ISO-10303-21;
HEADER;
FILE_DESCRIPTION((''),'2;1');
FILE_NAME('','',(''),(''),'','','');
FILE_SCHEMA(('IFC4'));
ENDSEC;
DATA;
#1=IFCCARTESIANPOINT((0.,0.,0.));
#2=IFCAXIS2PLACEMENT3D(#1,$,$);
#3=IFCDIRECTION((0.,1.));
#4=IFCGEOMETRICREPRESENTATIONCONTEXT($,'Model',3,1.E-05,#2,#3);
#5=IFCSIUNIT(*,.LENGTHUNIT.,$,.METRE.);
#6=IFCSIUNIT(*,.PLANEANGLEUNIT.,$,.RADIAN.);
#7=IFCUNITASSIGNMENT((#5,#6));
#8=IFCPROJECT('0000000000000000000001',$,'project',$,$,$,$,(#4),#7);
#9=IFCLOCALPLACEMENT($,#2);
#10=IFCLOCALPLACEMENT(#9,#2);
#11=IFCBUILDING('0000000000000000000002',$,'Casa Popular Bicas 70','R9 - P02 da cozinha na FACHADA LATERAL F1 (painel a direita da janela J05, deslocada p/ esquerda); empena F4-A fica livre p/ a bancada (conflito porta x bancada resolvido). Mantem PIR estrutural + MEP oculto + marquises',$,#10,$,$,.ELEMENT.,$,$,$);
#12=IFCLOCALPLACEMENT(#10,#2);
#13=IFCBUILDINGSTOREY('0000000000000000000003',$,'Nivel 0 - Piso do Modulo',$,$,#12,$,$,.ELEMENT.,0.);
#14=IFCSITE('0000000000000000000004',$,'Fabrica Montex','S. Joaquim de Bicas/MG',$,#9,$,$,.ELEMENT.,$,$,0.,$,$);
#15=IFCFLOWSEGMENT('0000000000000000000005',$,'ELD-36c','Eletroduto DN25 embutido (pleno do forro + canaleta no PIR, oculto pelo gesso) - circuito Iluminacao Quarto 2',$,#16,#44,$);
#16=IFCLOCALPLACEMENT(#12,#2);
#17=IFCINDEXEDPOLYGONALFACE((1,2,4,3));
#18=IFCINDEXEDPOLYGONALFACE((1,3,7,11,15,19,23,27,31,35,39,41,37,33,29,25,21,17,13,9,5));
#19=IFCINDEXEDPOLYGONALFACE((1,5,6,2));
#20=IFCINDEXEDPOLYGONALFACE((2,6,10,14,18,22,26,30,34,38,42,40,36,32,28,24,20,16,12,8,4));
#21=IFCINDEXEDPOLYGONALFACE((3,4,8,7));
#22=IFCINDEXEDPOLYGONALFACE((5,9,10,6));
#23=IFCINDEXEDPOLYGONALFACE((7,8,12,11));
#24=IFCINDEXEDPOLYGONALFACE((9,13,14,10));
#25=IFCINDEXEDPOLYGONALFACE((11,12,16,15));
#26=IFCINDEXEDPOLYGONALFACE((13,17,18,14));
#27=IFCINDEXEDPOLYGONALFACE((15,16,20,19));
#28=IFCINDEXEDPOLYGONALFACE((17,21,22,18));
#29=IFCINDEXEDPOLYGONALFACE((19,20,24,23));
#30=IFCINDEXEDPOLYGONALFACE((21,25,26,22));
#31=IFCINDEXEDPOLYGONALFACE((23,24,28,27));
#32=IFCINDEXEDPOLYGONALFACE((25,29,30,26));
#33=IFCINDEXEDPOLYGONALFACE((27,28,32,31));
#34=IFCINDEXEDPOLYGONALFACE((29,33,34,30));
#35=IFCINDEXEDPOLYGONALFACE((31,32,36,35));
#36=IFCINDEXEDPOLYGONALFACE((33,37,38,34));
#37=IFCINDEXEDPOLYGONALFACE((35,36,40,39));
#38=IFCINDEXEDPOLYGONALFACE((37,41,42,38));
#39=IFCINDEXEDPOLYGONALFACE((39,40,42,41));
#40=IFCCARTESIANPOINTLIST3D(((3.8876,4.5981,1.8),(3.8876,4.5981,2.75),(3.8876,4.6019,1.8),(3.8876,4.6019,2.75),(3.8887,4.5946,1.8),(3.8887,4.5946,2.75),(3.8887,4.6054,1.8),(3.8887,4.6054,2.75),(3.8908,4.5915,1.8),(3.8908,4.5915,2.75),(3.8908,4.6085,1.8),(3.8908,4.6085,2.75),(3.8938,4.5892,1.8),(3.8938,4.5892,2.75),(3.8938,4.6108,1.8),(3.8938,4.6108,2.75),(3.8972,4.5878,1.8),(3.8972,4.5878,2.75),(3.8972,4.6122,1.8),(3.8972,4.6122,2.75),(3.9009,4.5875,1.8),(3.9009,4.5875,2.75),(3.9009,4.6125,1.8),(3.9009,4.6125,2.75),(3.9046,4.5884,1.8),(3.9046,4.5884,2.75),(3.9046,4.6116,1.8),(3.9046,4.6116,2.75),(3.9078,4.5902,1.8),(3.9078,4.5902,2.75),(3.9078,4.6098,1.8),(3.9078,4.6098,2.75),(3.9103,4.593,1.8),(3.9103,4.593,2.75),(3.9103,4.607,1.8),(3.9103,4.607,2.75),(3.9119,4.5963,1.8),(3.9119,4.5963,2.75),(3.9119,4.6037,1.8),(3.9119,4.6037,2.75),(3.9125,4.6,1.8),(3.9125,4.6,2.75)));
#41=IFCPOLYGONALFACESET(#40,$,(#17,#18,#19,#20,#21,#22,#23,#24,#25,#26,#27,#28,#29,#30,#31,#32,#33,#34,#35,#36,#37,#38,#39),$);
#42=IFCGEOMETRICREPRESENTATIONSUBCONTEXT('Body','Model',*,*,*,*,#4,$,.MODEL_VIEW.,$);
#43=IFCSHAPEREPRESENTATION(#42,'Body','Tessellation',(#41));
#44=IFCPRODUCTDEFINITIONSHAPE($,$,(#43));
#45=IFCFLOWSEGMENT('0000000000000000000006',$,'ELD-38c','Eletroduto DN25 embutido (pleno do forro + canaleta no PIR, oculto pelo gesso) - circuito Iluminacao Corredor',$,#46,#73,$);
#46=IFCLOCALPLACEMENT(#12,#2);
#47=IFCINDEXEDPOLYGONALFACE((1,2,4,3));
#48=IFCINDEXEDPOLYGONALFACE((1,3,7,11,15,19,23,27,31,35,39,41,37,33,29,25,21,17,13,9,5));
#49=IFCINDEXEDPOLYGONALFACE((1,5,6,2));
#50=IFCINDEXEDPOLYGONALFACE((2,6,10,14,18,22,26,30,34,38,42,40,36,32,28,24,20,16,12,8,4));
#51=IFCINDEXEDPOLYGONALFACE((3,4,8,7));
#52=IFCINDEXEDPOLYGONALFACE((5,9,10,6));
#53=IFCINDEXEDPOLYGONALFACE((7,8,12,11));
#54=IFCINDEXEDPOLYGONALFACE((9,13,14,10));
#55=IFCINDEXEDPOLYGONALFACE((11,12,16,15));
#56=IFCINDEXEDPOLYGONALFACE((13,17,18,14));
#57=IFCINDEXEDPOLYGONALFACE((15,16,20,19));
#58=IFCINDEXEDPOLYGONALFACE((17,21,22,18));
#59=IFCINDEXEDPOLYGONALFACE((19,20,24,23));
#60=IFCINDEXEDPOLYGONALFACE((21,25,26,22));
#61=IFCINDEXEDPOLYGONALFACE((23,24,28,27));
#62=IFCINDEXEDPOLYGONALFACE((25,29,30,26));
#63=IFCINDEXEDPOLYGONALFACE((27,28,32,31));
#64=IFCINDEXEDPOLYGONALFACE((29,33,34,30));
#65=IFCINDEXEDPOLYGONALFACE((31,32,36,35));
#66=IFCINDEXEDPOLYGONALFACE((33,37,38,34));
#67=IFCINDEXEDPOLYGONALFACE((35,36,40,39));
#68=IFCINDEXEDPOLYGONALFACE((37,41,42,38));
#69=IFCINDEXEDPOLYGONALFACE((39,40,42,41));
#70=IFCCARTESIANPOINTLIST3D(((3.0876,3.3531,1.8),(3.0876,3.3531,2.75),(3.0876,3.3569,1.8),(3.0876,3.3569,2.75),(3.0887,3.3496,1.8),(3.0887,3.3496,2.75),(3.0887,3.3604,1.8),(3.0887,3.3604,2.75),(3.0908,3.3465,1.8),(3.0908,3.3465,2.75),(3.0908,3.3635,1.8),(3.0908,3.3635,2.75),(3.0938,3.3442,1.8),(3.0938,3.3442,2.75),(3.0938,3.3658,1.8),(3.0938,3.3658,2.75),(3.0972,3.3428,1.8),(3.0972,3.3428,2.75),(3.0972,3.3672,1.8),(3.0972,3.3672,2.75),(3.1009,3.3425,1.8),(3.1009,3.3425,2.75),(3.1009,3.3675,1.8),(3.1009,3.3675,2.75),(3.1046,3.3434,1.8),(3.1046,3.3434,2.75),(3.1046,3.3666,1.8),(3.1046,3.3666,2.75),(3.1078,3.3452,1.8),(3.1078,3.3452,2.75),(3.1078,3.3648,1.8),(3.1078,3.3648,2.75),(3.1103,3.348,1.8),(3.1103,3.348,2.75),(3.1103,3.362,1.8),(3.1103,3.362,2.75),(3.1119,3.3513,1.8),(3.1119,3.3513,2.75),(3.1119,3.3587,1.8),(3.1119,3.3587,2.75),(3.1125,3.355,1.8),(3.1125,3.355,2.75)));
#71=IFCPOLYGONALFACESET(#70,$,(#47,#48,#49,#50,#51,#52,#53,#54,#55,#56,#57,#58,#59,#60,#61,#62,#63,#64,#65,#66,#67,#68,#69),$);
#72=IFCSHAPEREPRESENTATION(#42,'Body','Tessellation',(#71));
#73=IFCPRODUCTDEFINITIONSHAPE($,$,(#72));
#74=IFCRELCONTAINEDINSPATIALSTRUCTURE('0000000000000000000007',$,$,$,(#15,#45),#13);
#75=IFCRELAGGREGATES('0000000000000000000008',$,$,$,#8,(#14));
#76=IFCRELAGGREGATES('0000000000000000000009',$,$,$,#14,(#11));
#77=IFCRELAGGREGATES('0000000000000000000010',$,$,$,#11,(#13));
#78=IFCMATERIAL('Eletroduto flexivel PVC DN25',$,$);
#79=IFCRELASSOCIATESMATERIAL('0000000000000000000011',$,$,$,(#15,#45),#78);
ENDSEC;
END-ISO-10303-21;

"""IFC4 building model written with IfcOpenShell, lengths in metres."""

from ifc_helpers import new_model, si_unit, direction, frame, origin, origin_2d, place, context, subcontext, project, spatial, circle, extrude, material, element, save


model = new_model("IFC4")

# Units and contexts
model_context = context("Model", 3, precision=1e-05, world=origin(), true_north=direction((0.0, 1.0)))
body_context = subcontext(model_context, "Body", "Model", "MODEL_VIEW")
ifc_project = project(units=[si_unit("LENGTHUNIT", "METRE"), si_unit("PLANEANGLEUNIT", "RADIAN")], contexts=[model_context])

# Site, building, storey
site_placement = place(None, origin())
site = spatial("IfcSite", under=ifc_project, at=site_placement, Name="Fabrica Montex", Description="S. Joaquim de Bicas/MG", CompositionType="ELEMENT", RefElevation=0.0)
building_placement = place(site_placement, origin())
building = spatial("IfcBuilding", under=site, at=building_placement, Name="Casa Popular Bicas 70", Description="R9 - P02 da cozinha na FACHADA LATERAL F1 (painel a direita da janela J05, deslocada p/ esquerda); empena F4-A fica livre p/ a bancada (conflito porta x bancada resolvido). Mantem PIR estrutural + MEP oculto + marquises", CompositionType="ELEMENT")
storey_placement = place(building_placement, origin())
storey = spatial("IfcBuildingStorey", under=building, at=storey_placement, Name="Nivel 0 - Piso do Modulo", CompositionType="ELEMENT", Elevation=0.0)

# Shared definitions
ifc_material_1 = material(Name="Eletroduto flexivel PVC DN25")

# Flow segments
for number, where, z_axis, x_axis, name, description in (
    (1, (3.9, 4.6, 2.75), (0.0, 0.0, -1.0), (1.0, 0.0, 0.0), "ELD-36c", "Eletroduto DN25 embutido (pleno do forro + canaleta no PIR, oculto pelo gesso) - circuito Iluminacao Quarto 2"),
    (2, (3.1, 3.355, 2.75), (0.0, 0.0, -1.0), (1.0, 0.0, 0.0), "ELD-38c", "Eletroduto DN25 embutido (pleno do forro + canaleta no PIR, oculto pelo gesso) - circuito Iluminacao Corredor"),
):
    element("IfcFlowSegment", number, at=place(storey_placement, frame(where, z_axis=z_axis, x_axis=x_axis)), inside=storey, material=ifc_material_1, Name=name, Description=description, context=body_context, shape_type="SweptSolid", body=[
        extrude(circle(Radius=0.0125, at=origin_2d()), origin(), (0.0, 0.0, 1.0), 0.95),
    ])

save(model, "model.ifc")
